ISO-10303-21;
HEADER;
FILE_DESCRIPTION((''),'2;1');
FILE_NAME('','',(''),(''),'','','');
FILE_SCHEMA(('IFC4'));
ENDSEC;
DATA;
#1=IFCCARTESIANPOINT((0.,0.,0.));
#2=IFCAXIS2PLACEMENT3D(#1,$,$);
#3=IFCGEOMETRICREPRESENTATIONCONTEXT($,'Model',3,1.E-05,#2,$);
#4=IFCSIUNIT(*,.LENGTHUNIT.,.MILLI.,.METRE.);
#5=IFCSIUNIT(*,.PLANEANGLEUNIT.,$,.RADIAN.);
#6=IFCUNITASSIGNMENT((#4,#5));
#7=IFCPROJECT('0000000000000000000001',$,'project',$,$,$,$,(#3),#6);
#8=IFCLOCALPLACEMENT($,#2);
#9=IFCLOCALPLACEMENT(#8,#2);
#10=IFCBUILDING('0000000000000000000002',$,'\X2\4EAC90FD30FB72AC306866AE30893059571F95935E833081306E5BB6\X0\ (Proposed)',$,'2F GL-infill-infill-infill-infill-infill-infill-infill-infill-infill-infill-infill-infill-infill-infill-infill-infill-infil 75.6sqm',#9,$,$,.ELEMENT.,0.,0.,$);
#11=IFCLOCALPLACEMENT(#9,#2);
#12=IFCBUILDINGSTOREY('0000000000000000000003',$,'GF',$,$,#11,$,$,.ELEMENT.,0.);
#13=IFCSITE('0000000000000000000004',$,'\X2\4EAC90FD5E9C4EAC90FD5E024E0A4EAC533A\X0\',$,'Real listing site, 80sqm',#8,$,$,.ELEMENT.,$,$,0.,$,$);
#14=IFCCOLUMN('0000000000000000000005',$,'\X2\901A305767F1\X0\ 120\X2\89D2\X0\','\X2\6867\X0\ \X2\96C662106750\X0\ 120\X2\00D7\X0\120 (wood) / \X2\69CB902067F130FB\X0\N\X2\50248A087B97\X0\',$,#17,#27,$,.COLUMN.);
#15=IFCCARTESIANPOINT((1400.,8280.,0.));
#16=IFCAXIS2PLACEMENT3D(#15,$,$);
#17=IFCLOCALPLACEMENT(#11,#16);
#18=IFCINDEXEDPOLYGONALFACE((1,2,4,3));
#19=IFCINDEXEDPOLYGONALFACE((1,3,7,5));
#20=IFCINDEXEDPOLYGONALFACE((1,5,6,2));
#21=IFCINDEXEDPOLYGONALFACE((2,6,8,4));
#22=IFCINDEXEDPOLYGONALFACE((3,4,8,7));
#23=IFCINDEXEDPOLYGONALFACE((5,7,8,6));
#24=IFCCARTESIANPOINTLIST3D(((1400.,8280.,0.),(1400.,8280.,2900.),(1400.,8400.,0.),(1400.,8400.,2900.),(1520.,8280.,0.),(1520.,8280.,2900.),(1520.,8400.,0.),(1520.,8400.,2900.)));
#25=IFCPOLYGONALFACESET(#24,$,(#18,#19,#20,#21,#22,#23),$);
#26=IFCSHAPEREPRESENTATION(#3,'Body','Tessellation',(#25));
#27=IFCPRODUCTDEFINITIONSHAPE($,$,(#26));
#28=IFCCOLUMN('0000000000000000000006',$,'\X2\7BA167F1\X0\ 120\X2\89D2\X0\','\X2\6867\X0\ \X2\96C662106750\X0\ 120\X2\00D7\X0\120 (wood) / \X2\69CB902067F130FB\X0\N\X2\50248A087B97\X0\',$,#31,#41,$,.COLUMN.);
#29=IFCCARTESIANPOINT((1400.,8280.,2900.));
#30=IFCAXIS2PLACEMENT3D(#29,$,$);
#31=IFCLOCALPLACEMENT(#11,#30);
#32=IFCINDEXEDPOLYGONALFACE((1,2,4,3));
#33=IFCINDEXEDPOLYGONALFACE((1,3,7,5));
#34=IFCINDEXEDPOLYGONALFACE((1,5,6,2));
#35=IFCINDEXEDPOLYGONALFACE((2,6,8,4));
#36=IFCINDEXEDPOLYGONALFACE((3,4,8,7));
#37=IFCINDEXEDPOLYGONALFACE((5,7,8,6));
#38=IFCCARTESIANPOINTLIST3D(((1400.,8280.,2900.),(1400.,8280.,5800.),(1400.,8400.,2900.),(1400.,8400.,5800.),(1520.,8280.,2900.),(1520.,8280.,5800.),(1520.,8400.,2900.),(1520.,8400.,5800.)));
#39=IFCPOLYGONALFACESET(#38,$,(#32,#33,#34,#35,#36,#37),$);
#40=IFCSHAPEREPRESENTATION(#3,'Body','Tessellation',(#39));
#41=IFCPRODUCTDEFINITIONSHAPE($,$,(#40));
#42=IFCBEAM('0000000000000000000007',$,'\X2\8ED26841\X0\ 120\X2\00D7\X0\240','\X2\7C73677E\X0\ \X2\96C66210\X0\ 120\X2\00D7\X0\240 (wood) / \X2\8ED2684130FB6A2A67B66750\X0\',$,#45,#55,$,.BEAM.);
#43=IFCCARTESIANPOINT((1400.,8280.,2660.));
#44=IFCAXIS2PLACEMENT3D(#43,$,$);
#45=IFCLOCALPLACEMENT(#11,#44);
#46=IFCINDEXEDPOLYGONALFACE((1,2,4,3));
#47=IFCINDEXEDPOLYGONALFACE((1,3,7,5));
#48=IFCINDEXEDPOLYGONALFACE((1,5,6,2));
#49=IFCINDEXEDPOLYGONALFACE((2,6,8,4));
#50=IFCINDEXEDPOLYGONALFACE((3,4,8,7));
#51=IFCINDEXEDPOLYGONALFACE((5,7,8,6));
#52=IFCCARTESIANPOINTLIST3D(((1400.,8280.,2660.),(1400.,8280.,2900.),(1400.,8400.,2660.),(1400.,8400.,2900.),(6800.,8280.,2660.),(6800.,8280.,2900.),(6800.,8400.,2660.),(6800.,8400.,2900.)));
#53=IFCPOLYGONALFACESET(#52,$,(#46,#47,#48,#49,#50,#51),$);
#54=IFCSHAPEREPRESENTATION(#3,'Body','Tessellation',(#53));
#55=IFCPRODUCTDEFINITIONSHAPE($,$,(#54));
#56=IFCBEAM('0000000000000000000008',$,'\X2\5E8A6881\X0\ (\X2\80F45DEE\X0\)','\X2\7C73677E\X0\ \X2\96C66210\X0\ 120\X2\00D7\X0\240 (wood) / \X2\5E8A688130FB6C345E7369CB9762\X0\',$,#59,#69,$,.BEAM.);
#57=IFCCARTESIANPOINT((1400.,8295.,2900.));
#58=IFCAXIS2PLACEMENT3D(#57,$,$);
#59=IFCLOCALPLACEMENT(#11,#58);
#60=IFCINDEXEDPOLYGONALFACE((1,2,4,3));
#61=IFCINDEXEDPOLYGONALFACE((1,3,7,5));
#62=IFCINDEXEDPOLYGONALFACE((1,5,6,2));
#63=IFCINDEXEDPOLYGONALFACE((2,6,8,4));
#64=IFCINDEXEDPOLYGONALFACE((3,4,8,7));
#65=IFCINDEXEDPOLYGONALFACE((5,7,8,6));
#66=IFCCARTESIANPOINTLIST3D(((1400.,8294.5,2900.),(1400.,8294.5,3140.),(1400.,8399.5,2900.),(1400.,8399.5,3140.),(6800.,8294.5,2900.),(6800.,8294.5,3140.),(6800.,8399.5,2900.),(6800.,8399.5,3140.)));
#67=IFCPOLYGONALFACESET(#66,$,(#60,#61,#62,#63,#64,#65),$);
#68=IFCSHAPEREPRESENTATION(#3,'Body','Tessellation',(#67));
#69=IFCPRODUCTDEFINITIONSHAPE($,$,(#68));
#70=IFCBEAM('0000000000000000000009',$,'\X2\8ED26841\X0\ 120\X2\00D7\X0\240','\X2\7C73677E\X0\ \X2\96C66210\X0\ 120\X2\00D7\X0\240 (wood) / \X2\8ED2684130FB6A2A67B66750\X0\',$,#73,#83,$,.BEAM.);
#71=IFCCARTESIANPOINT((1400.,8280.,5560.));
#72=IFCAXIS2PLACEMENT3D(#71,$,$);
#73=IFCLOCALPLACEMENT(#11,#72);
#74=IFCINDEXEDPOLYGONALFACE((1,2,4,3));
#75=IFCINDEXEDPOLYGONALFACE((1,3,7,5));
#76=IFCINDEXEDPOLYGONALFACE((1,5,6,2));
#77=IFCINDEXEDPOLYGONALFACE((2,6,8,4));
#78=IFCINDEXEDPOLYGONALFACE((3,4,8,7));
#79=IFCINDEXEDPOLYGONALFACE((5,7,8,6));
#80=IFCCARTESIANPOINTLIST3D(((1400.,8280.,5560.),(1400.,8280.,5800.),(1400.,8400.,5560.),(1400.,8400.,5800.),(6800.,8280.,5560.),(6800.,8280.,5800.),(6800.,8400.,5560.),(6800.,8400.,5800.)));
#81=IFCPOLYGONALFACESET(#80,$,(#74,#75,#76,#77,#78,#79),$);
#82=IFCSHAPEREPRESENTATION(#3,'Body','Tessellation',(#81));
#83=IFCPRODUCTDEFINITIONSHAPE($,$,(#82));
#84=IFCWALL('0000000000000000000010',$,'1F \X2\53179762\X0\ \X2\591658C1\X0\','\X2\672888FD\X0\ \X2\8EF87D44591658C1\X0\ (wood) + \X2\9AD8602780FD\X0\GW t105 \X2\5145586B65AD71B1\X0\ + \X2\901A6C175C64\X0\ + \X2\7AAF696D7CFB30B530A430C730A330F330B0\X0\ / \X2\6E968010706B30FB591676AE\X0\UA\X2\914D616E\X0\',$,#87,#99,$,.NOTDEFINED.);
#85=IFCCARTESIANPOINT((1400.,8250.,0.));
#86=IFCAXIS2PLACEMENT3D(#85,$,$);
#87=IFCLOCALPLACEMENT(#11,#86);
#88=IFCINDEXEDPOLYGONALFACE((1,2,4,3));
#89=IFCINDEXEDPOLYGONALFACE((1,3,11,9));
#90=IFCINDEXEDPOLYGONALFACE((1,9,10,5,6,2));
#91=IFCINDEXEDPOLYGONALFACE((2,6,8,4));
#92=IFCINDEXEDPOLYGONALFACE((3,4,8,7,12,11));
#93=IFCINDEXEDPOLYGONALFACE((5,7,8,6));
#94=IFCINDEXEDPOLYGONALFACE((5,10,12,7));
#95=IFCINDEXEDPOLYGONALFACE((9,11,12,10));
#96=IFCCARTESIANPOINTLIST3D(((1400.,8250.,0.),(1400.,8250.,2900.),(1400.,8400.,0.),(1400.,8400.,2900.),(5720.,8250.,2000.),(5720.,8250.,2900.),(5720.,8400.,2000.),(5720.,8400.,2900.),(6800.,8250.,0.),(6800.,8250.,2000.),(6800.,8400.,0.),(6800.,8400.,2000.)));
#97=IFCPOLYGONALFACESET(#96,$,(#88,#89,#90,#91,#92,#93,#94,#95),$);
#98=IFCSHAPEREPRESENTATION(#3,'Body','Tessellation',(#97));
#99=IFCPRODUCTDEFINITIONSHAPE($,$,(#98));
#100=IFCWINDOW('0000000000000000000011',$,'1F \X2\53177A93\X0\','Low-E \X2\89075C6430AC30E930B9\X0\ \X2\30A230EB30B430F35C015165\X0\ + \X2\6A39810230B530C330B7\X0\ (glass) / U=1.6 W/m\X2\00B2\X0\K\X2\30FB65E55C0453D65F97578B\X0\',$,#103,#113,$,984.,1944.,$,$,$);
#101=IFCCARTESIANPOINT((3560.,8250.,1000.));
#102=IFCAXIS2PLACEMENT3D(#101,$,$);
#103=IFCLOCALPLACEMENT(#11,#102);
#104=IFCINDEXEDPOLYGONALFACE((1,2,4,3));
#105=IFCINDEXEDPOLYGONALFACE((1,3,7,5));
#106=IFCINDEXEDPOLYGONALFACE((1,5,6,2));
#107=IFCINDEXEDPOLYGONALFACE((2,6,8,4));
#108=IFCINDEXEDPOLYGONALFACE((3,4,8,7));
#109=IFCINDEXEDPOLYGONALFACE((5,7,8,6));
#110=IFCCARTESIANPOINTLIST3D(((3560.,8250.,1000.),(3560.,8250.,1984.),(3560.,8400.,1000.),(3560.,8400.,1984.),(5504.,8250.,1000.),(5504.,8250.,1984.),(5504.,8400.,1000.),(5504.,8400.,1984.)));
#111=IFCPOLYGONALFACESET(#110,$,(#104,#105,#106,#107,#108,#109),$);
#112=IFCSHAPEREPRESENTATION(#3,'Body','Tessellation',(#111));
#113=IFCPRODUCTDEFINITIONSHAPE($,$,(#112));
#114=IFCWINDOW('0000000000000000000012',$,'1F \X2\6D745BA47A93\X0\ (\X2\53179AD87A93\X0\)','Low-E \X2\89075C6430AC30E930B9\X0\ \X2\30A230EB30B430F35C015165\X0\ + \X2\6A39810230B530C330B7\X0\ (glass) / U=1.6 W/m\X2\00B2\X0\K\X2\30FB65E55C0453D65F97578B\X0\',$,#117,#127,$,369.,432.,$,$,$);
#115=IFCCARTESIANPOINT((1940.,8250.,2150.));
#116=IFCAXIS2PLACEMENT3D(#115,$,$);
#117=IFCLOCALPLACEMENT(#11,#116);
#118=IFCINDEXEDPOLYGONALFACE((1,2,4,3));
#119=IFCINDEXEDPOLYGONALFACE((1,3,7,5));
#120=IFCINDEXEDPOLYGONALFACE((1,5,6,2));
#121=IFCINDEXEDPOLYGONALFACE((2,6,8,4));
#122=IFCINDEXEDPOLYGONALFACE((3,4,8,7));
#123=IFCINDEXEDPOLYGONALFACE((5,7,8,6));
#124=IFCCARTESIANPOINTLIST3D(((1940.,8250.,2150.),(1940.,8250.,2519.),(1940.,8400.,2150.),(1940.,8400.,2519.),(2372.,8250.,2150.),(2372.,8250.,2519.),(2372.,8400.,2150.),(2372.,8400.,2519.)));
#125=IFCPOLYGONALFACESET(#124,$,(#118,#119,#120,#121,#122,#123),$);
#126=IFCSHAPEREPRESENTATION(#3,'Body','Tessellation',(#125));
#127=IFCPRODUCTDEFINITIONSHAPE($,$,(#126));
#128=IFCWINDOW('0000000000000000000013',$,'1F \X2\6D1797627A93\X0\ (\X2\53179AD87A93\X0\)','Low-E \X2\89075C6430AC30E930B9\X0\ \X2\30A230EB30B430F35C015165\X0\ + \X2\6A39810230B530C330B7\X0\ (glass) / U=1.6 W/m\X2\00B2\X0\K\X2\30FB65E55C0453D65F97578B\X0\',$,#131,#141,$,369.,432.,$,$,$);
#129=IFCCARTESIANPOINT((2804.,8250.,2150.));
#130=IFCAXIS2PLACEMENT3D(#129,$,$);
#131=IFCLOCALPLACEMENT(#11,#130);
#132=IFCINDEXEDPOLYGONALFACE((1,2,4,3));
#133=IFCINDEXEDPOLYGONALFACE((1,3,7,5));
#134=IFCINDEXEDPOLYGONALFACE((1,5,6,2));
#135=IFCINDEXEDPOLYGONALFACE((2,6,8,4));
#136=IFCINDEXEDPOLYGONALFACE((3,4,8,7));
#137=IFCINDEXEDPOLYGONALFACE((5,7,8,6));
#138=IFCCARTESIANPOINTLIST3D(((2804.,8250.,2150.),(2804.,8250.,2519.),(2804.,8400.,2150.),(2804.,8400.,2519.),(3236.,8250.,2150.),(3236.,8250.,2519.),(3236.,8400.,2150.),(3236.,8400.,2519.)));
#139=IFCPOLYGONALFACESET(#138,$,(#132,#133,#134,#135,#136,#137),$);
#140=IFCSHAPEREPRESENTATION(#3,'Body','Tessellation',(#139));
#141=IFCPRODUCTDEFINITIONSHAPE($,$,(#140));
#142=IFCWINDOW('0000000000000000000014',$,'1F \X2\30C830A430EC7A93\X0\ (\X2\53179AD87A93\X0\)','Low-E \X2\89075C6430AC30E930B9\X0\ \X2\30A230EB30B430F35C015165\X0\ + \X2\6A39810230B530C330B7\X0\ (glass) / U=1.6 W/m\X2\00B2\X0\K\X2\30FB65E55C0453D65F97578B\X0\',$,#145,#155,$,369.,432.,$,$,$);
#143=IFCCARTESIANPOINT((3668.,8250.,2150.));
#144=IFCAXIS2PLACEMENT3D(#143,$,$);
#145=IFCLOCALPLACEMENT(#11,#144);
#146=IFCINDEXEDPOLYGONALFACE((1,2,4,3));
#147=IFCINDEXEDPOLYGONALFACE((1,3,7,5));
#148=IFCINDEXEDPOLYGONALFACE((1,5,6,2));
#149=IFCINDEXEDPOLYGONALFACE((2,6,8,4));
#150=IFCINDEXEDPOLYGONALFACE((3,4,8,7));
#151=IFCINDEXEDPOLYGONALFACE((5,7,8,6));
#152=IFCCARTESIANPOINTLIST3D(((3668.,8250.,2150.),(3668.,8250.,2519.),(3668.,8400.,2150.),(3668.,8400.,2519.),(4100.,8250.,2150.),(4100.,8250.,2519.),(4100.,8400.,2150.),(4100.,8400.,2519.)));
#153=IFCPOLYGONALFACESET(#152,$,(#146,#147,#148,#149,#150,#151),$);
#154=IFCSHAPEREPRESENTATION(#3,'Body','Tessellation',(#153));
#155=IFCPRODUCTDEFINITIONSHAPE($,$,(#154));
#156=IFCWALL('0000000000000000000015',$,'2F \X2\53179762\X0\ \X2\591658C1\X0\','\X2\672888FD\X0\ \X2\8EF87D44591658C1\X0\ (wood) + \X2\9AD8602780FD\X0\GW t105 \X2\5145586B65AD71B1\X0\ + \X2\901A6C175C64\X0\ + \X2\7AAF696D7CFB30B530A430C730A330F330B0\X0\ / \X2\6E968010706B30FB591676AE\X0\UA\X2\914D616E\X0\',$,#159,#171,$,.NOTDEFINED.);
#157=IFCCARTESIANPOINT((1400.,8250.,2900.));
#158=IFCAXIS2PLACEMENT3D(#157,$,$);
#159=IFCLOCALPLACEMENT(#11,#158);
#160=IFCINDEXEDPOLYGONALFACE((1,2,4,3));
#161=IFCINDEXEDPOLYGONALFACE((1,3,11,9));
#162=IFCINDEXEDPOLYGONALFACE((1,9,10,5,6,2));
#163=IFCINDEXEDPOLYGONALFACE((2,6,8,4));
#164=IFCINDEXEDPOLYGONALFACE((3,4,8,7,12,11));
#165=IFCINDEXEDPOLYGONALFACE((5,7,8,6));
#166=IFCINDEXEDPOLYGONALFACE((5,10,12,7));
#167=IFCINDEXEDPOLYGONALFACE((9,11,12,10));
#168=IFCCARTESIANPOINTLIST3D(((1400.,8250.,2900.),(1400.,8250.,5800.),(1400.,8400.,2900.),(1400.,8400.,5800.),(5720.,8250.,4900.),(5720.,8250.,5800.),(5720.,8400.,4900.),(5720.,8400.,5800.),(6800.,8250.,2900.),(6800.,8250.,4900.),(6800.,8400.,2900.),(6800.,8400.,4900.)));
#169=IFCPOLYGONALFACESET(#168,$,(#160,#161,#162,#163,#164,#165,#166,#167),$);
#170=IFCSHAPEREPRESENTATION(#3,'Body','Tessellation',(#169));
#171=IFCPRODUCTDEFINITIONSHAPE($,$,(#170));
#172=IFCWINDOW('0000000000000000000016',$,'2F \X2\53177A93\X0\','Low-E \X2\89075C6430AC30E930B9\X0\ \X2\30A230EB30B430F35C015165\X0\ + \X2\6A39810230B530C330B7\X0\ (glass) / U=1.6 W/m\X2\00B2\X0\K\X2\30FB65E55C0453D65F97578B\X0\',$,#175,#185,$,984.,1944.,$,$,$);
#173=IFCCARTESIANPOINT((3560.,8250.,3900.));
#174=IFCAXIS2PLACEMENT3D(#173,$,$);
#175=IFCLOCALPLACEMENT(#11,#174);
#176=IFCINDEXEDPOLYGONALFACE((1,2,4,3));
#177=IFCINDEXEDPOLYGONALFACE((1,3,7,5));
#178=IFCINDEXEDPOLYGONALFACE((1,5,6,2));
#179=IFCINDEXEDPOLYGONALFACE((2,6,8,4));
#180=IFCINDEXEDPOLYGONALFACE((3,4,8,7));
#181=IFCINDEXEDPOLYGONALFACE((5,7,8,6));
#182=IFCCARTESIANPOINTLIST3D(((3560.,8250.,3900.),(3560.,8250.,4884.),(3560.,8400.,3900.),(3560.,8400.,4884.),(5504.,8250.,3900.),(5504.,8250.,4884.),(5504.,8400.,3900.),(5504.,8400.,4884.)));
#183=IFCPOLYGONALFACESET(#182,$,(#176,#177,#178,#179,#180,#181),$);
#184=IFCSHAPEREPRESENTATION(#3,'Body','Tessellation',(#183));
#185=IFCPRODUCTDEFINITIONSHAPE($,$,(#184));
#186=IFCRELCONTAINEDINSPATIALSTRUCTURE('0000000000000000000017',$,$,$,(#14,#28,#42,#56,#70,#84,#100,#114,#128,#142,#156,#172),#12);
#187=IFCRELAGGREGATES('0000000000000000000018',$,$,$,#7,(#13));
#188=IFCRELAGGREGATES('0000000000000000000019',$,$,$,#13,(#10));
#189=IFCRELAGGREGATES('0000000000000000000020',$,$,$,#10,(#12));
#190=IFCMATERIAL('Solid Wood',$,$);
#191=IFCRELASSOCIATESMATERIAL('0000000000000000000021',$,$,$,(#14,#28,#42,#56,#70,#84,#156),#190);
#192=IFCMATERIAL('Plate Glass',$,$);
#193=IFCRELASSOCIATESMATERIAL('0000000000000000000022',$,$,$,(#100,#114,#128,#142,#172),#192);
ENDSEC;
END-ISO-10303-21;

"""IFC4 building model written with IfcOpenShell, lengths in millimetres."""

from ifc_helpers import new_model, si_unit, frame, frame_2d, origin, place, context, project, spatial, rectangle, extrude, material, element, fill, save


model = new_model("IFC4")

# Units and contexts
model_context = context("Model", 3, precision=1e-05, world=origin())
ifc_project = project(units=[si_unit("LENGTHUNIT", "METRE", prefix="MILLI"), si_unit("PLANEANGLEUNIT", "RADIAN")], contexts=[model_context])

# Site, building, storey
site_placement = place(None, origin())
site = spatial("IfcSite", under=ifc_project, at=site_placement, Name="京都府京都市上京区", ObjectType="Real listing site, 80sqm", CompositionType="ELEMENT", RefElevation=0.0)
building_placement = place(site_placement, origin())
building = spatial("IfcBuilding", under=site, at=building_placement, Name="京都・犬と暮らす土間広めの家 (Proposed)", ObjectType="2F GL-infill-infill-infill-infill-infill-infill-infill-infill-infill-infill-infill-infill-infill-infill-infill-infill-infil 75.6sqm", CompositionType="ELEMENT", ElevationOfRefHeight=0.0, ElevationOfTerrain=0.0)
storey_placement = place(building_placement, origin())
storey = spatial("IfcBuildingStorey", under=building, at=storey_placement, Name="GF", CompositionType="ELEMENT", Elevation=0.0)

# Columns
ifc_material_1 = material(Name="Solid Wood")
column_1_placement = place(storey_placement, frame((1400.0, 8280.0, 0.0)))
element("IfcColumn", 1, at=column_1_placement, inside=storey, material=ifc_material_1, Name="通し柱 120角", Description="桧 集成材 120×120 (wood) / 構造柱・N値計算", PredefinedType="COLUMN", context=model_context, shape_type="SweptSolid", body=[
    extrude(rectangle(XDim=120.0, YDim=120.0, at=frame_2d((60.0, 60.0))), frame((1400.0, 8280.0, 0.0)), (0.0, 0.0, 1.0), 2900.0),
])
column_2_placement = place(storey_placement, frame((1400.0, 8280.0, 2900.0)))
element("IfcColumn", 2, at=column_2_placement, inside=storey, material=ifc_material_1, Name="管柱 120角", Description="桧 集成材 120×120 (wood) / 構造柱・N値計算", PredefinedType="COLUMN", context=model_context, shape_type="SweptSolid", body=[
    extrude(rectangle(XDim=120.0, YDim=120.0, at=frame_2d((60.0, 60.0))), frame((1400.0, 8280.0, 2900.0)), (0.0, 0.0, 1.0), 2900.0),
])

# Beams
beam_1_placement = place(storey_placement, frame((1400.0, 8280.0, 2660.0)))
element("IfcBeam", 3, at=beam_1_placement, inside=storey, material=ifc_material_1, Name="軒桁 120×240", Description="米松 集成 120×240 (wood) / 軒桁・横架材", PredefinedType="BEAM", context=model_context, shape_type="SweptSolid", body=[
    extrude(rectangle(XDim=5400.0, YDim=120.0, at=frame_2d((2700.0, 60.0))), frame((1400.0, 8280.0, 2660.0)), (0.0, 0.0, 1.0), 240.0),
])
beam_2_placement = place(storey_placement, frame((1400.0, 8295.0, 2900.0)))
element("IfcBeam", 4, at=beam_2_placement, inside=storey, material=ifc_material_1, Name="床梁 (胴差)", Description="米松 集成 120×240 (wood) / 床梁・水平構面", PredefinedType="BEAM", context=model_context, shape_type="SweptSolid", body=[
    extrude(rectangle(XDim=5400.0, YDim=105.0, at=frame_2d((2700.0, 52.0))), frame((1400.0, 8295.0, 2900.0)), (0.0, 0.0, 1.0), 240.0),
])
beam_3_placement = place(storey_placement, frame((1400.0, 8280.0, 5560.0)))
element("IfcBeam", 5, at=beam_3_placement, inside=storey, material=ifc_material_1, Name="軒桁 120×240", Description="米松 集成 120×240 (wood) / 軒桁・横架材", PredefinedType="BEAM", context=model_context, shape_type="SweptSolid", body=[
    extrude(rectangle(XDim=5400.0, YDim=120.0, at=frame_2d((2700.0, 60.0))), frame((1400.0, 8280.0, 5560.0)), (0.0, 0.0, 1.0), 240.0),
])

# Wall, openings, windows
wall_1_placement = place(storey_placement, frame((1400.0, 8250.0, 0.0)))
wall_1 = element("IfcWall", 6, at=wall_1_placement, inside=storey, material=ifc_material_1, Name="1F 北面 外壁", Description="木製 軸組外壁 (wood) + 高性能GW t105 充填断熱 + 通気層 + 窯業系サイディング / 準耐火・外皮UA配慮", PredefinedType="NOTDEFINED", context=model_context, shape_type="SweptSolid", body=[
    extrude(rectangle(XDim=5400.0, YDim=150.0, at=frame_2d((2700.0, 75.0))), frame((1400.0, 8250.0, 0.0)), (0.0, 0.0, 1.0), 2900.0),
])
opening_1_placement = place(storey_placement, frame((3560.0, 8250.0, 1000.0)))
opening_1 = element("IfcOpeningElement", 7, at=opening_1_placement, cuts=wall_1, PredefinedType="NOTDEFINED", context=model_context, shape_type="SweptSolid", body=[
    extrude(rectangle(XDim=1944.0, YDim=150.0, at=frame_2d((972.0, 75.0))), frame((3560.0, 8250.0, 1000.0)), (0.0, 0.0, 1.0), 984.0),
])
opening_2_placement = place(storey_placement, frame((1940.0, 8250.0, 2150.0)))
opening_2 = element("IfcOpeningElement", 8, at=opening_2_placement, cuts=wall_1, PredefinedType="NOTDEFINED", context=model_context, shape_type="SweptSolid", body=[
    extrude(rectangle(XDim=432.0, YDim=150.0, at=frame_2d((216.0, 75.0))), frame((1940.0, 8250.0, 2150.0)), (0.0, 0.0, 1.0), 369.0),
])
opening_3_placement = place(storey_placement, frame((2804.0, 8250.0, 2150.0)))
opening_3 = element("IfcOpeningElement", 9, at=opening_3_placement, cuts=wall_1, PredefinedType="NOTDEFINED", context=model_context, shape_type="SweptSolid", body=[
    extrude(rectangle(XDim=432.0, YDim=150.0, at=frame_2d((216.0, 75.0))), frame((2804.0, 8250.0, 2150.0)), (0.0, 0.0, 1.0), 369.0),
])
opening_4_placement = place(storey_placement, frame((3668.0, 8250.0, 2150.0)))
opening_4 = element("IfcOpeningElement", 10, at=opening_4_placement, cuts=wall_1, PredefinedType="NOTDEFINED", context=model_context, shape_type="SweptSolid", body=[
    extrude(rectangle(XDim=432.0, YDim=150.0, at=frame_2d((216.0, 75.0))), frame((3668.0, 8250.0, 2150.0)), (0.0, 0.0, 1.0), 369.0),
])
ifc_material_2 = material(Name="Plate Glass")
window_1_placement = place(storey_placement, frame((3560.0, 8250.0, 1000.0)))
window_1 = element("IfcWindow", 11, at=window_1_placement, inside=storey, material=ifc_material_2, Name="1F 北窓", Description="Low-E 複層ガラス アルゴン封入 + 樹脂サッシ (glass) / U=1.6 W/m²K・日射取得型", OverallHeight=984.0, OverallWidth=1944.0, context=model_context, shape_type="SweptSolid", body=[
    extrude(rectangle(XDim=1944.0, YDim=150.0, at=frame_2d((972.0, 75.0))), frame((3560.0, 8250.0, 1000.0)), (0.0, 0.0, 1.0), 984.0),
])
fill(opening_1, window_1)
window_2_placement = place(storey_placement, frame((1940.0, 8250.0, 2150.0)))
window_2 = element("IfcWindow", 12, at=window_2_placement, inside=storey, material=ifc_material_2, Name="1F 浴室窓 (北高窓)", Description="Low-E 複層ガラス アルゴン封入 + 樹脂サッシ (glass) / U=1.6 W/m²K・日射取得型", OverallHeight=369.0, OverallWidth=432.0, context=model_context, shape_type="SweptSolid", body=[
    extrude(rectangle(XDim=432.0, YDim=150.0, at=frame_2d((216.0, 75.0))), frame((1940.0, 8250.0, 2150.0)), (0.0, 0.0, 1.0), 369.0),
])
fill(opening_2, window_2)
window_3_placement = place(storey_placement, frame((2804.0, 8250.0, 2150.0)))
window_3 = element("IfcWindow", 13, at=window_3_placement, inside=storey, material=ifc_material_2, Name="1F 洗面窓 (北高窓)", Description="Low-E 複層ガラス アルゴン封入 + 樹脂サッシ (glass) / U=1.6 W/m²K・日射取得型", OverallHeight=369.0, OverallWidth=432.0, context=model_context, shape_type="SweptSolid", body=[
    extrude(rectangle(XDim=432.0, YDim=150.0, at=frame_2d((216.0, 75.0))), frame((2804.0, 8250.0, 2150.0)), (0.0, 0.0, 1.0), 369.0),
])
fill(opening_3, window_3)
window_4_placement = place(storey_placement, frame((3668.0, 8250.0, 2150.0)))
window_4 = element("IfcWindow", 14, at=window_4_placement, inside=storey, material=ifc_material_2, Name="1F トイレ窓 (北高窓)", Description="Low-E 複層ガラス アルゴン封入 + 樹脂サッシ (glass) / U=1.6 W/m²K・日射取得型", OverallHeight=369.0, OverallWidth=432.0, context=model_context, shape_type="SweptSolid", body=[
    extrude(rectangle(XDim=432.0, YDim=150.0, at=frame_2d((216.0, 75.0))), frame((3668.0, 8250.0, 2150.0)), (0.0, 0.0, 1.0), 369.0),
])
fill(opening_4, window_4)

# Wall, opening, window
wall_2_placement = place(storey_placement, frame((1400.0, 8250.0, 2900.0)))
wall_2 = element("IfcWall", 15, at=wall_2_placement, inside=storey, material=ifc_material_1, Name="2F 北面 外壁", Description="木製 軸組外壁 (wood) + 高性能GW t105 充填断熱 + 通気層 + 窯業系サイディング / 準耐火・外皮UA配慮", PredefinedType="NOTDEFINED", context=model_context, shape_type="SweptSolid", body=[
    extrude(rectangle(XDim=5400.0, YDim=150.0, at=frame_2d((2700.0, 75.0))), frame((1400.0, 8250.0, 2900.0)), (0.0, 0.0, 1.0), 2900.0),
])
opening_5_placement = place(storey_placement, frame((3560.0, 8250.0, 3900.0)))
opening_5 = element("IfcOpeningElement", 16, at=opening_5_placement, cuts=wall_2, PredefinedType="NOTDEFINED", context=model_context, shape_type="SweptSolid", body=[
    extrude(rectangle(XDim=1944.0, YDim=150.0, at=frame_2d((972.0, 75.0))), frame((3560.0, 8250.0, 3900.0)), (0.0, 0.0, 1.0), 984.0),
])
window_5_placement = place(storey_placement, frame((3560.0, 8250.0, 3900.0)))
window_5 = element("IfcWindow", 17, at=window_5_placement, inside=storey, material=ifc_material_2, Name="2F 北窓", Description="Low-E 複層ガラス アルゴン封入 + 樹脂サッシ (glass) / U=1.6 W/m²K・日射取得型", OverallHeight=984.0, OverallWidth=1944.0, context=model_context, shape_type="SweptSolid", body=[
    extrude(rectangle(XDim=1944.0, YDim=150.0, at=frame_2d((972.0, 75.0))), frame((3560.0, 8250.0, 3900.0)), (0.0, 0.0, 1.0), 984.0),
])
fill(opening_5, window_5)

save(model, "model.ifc")
